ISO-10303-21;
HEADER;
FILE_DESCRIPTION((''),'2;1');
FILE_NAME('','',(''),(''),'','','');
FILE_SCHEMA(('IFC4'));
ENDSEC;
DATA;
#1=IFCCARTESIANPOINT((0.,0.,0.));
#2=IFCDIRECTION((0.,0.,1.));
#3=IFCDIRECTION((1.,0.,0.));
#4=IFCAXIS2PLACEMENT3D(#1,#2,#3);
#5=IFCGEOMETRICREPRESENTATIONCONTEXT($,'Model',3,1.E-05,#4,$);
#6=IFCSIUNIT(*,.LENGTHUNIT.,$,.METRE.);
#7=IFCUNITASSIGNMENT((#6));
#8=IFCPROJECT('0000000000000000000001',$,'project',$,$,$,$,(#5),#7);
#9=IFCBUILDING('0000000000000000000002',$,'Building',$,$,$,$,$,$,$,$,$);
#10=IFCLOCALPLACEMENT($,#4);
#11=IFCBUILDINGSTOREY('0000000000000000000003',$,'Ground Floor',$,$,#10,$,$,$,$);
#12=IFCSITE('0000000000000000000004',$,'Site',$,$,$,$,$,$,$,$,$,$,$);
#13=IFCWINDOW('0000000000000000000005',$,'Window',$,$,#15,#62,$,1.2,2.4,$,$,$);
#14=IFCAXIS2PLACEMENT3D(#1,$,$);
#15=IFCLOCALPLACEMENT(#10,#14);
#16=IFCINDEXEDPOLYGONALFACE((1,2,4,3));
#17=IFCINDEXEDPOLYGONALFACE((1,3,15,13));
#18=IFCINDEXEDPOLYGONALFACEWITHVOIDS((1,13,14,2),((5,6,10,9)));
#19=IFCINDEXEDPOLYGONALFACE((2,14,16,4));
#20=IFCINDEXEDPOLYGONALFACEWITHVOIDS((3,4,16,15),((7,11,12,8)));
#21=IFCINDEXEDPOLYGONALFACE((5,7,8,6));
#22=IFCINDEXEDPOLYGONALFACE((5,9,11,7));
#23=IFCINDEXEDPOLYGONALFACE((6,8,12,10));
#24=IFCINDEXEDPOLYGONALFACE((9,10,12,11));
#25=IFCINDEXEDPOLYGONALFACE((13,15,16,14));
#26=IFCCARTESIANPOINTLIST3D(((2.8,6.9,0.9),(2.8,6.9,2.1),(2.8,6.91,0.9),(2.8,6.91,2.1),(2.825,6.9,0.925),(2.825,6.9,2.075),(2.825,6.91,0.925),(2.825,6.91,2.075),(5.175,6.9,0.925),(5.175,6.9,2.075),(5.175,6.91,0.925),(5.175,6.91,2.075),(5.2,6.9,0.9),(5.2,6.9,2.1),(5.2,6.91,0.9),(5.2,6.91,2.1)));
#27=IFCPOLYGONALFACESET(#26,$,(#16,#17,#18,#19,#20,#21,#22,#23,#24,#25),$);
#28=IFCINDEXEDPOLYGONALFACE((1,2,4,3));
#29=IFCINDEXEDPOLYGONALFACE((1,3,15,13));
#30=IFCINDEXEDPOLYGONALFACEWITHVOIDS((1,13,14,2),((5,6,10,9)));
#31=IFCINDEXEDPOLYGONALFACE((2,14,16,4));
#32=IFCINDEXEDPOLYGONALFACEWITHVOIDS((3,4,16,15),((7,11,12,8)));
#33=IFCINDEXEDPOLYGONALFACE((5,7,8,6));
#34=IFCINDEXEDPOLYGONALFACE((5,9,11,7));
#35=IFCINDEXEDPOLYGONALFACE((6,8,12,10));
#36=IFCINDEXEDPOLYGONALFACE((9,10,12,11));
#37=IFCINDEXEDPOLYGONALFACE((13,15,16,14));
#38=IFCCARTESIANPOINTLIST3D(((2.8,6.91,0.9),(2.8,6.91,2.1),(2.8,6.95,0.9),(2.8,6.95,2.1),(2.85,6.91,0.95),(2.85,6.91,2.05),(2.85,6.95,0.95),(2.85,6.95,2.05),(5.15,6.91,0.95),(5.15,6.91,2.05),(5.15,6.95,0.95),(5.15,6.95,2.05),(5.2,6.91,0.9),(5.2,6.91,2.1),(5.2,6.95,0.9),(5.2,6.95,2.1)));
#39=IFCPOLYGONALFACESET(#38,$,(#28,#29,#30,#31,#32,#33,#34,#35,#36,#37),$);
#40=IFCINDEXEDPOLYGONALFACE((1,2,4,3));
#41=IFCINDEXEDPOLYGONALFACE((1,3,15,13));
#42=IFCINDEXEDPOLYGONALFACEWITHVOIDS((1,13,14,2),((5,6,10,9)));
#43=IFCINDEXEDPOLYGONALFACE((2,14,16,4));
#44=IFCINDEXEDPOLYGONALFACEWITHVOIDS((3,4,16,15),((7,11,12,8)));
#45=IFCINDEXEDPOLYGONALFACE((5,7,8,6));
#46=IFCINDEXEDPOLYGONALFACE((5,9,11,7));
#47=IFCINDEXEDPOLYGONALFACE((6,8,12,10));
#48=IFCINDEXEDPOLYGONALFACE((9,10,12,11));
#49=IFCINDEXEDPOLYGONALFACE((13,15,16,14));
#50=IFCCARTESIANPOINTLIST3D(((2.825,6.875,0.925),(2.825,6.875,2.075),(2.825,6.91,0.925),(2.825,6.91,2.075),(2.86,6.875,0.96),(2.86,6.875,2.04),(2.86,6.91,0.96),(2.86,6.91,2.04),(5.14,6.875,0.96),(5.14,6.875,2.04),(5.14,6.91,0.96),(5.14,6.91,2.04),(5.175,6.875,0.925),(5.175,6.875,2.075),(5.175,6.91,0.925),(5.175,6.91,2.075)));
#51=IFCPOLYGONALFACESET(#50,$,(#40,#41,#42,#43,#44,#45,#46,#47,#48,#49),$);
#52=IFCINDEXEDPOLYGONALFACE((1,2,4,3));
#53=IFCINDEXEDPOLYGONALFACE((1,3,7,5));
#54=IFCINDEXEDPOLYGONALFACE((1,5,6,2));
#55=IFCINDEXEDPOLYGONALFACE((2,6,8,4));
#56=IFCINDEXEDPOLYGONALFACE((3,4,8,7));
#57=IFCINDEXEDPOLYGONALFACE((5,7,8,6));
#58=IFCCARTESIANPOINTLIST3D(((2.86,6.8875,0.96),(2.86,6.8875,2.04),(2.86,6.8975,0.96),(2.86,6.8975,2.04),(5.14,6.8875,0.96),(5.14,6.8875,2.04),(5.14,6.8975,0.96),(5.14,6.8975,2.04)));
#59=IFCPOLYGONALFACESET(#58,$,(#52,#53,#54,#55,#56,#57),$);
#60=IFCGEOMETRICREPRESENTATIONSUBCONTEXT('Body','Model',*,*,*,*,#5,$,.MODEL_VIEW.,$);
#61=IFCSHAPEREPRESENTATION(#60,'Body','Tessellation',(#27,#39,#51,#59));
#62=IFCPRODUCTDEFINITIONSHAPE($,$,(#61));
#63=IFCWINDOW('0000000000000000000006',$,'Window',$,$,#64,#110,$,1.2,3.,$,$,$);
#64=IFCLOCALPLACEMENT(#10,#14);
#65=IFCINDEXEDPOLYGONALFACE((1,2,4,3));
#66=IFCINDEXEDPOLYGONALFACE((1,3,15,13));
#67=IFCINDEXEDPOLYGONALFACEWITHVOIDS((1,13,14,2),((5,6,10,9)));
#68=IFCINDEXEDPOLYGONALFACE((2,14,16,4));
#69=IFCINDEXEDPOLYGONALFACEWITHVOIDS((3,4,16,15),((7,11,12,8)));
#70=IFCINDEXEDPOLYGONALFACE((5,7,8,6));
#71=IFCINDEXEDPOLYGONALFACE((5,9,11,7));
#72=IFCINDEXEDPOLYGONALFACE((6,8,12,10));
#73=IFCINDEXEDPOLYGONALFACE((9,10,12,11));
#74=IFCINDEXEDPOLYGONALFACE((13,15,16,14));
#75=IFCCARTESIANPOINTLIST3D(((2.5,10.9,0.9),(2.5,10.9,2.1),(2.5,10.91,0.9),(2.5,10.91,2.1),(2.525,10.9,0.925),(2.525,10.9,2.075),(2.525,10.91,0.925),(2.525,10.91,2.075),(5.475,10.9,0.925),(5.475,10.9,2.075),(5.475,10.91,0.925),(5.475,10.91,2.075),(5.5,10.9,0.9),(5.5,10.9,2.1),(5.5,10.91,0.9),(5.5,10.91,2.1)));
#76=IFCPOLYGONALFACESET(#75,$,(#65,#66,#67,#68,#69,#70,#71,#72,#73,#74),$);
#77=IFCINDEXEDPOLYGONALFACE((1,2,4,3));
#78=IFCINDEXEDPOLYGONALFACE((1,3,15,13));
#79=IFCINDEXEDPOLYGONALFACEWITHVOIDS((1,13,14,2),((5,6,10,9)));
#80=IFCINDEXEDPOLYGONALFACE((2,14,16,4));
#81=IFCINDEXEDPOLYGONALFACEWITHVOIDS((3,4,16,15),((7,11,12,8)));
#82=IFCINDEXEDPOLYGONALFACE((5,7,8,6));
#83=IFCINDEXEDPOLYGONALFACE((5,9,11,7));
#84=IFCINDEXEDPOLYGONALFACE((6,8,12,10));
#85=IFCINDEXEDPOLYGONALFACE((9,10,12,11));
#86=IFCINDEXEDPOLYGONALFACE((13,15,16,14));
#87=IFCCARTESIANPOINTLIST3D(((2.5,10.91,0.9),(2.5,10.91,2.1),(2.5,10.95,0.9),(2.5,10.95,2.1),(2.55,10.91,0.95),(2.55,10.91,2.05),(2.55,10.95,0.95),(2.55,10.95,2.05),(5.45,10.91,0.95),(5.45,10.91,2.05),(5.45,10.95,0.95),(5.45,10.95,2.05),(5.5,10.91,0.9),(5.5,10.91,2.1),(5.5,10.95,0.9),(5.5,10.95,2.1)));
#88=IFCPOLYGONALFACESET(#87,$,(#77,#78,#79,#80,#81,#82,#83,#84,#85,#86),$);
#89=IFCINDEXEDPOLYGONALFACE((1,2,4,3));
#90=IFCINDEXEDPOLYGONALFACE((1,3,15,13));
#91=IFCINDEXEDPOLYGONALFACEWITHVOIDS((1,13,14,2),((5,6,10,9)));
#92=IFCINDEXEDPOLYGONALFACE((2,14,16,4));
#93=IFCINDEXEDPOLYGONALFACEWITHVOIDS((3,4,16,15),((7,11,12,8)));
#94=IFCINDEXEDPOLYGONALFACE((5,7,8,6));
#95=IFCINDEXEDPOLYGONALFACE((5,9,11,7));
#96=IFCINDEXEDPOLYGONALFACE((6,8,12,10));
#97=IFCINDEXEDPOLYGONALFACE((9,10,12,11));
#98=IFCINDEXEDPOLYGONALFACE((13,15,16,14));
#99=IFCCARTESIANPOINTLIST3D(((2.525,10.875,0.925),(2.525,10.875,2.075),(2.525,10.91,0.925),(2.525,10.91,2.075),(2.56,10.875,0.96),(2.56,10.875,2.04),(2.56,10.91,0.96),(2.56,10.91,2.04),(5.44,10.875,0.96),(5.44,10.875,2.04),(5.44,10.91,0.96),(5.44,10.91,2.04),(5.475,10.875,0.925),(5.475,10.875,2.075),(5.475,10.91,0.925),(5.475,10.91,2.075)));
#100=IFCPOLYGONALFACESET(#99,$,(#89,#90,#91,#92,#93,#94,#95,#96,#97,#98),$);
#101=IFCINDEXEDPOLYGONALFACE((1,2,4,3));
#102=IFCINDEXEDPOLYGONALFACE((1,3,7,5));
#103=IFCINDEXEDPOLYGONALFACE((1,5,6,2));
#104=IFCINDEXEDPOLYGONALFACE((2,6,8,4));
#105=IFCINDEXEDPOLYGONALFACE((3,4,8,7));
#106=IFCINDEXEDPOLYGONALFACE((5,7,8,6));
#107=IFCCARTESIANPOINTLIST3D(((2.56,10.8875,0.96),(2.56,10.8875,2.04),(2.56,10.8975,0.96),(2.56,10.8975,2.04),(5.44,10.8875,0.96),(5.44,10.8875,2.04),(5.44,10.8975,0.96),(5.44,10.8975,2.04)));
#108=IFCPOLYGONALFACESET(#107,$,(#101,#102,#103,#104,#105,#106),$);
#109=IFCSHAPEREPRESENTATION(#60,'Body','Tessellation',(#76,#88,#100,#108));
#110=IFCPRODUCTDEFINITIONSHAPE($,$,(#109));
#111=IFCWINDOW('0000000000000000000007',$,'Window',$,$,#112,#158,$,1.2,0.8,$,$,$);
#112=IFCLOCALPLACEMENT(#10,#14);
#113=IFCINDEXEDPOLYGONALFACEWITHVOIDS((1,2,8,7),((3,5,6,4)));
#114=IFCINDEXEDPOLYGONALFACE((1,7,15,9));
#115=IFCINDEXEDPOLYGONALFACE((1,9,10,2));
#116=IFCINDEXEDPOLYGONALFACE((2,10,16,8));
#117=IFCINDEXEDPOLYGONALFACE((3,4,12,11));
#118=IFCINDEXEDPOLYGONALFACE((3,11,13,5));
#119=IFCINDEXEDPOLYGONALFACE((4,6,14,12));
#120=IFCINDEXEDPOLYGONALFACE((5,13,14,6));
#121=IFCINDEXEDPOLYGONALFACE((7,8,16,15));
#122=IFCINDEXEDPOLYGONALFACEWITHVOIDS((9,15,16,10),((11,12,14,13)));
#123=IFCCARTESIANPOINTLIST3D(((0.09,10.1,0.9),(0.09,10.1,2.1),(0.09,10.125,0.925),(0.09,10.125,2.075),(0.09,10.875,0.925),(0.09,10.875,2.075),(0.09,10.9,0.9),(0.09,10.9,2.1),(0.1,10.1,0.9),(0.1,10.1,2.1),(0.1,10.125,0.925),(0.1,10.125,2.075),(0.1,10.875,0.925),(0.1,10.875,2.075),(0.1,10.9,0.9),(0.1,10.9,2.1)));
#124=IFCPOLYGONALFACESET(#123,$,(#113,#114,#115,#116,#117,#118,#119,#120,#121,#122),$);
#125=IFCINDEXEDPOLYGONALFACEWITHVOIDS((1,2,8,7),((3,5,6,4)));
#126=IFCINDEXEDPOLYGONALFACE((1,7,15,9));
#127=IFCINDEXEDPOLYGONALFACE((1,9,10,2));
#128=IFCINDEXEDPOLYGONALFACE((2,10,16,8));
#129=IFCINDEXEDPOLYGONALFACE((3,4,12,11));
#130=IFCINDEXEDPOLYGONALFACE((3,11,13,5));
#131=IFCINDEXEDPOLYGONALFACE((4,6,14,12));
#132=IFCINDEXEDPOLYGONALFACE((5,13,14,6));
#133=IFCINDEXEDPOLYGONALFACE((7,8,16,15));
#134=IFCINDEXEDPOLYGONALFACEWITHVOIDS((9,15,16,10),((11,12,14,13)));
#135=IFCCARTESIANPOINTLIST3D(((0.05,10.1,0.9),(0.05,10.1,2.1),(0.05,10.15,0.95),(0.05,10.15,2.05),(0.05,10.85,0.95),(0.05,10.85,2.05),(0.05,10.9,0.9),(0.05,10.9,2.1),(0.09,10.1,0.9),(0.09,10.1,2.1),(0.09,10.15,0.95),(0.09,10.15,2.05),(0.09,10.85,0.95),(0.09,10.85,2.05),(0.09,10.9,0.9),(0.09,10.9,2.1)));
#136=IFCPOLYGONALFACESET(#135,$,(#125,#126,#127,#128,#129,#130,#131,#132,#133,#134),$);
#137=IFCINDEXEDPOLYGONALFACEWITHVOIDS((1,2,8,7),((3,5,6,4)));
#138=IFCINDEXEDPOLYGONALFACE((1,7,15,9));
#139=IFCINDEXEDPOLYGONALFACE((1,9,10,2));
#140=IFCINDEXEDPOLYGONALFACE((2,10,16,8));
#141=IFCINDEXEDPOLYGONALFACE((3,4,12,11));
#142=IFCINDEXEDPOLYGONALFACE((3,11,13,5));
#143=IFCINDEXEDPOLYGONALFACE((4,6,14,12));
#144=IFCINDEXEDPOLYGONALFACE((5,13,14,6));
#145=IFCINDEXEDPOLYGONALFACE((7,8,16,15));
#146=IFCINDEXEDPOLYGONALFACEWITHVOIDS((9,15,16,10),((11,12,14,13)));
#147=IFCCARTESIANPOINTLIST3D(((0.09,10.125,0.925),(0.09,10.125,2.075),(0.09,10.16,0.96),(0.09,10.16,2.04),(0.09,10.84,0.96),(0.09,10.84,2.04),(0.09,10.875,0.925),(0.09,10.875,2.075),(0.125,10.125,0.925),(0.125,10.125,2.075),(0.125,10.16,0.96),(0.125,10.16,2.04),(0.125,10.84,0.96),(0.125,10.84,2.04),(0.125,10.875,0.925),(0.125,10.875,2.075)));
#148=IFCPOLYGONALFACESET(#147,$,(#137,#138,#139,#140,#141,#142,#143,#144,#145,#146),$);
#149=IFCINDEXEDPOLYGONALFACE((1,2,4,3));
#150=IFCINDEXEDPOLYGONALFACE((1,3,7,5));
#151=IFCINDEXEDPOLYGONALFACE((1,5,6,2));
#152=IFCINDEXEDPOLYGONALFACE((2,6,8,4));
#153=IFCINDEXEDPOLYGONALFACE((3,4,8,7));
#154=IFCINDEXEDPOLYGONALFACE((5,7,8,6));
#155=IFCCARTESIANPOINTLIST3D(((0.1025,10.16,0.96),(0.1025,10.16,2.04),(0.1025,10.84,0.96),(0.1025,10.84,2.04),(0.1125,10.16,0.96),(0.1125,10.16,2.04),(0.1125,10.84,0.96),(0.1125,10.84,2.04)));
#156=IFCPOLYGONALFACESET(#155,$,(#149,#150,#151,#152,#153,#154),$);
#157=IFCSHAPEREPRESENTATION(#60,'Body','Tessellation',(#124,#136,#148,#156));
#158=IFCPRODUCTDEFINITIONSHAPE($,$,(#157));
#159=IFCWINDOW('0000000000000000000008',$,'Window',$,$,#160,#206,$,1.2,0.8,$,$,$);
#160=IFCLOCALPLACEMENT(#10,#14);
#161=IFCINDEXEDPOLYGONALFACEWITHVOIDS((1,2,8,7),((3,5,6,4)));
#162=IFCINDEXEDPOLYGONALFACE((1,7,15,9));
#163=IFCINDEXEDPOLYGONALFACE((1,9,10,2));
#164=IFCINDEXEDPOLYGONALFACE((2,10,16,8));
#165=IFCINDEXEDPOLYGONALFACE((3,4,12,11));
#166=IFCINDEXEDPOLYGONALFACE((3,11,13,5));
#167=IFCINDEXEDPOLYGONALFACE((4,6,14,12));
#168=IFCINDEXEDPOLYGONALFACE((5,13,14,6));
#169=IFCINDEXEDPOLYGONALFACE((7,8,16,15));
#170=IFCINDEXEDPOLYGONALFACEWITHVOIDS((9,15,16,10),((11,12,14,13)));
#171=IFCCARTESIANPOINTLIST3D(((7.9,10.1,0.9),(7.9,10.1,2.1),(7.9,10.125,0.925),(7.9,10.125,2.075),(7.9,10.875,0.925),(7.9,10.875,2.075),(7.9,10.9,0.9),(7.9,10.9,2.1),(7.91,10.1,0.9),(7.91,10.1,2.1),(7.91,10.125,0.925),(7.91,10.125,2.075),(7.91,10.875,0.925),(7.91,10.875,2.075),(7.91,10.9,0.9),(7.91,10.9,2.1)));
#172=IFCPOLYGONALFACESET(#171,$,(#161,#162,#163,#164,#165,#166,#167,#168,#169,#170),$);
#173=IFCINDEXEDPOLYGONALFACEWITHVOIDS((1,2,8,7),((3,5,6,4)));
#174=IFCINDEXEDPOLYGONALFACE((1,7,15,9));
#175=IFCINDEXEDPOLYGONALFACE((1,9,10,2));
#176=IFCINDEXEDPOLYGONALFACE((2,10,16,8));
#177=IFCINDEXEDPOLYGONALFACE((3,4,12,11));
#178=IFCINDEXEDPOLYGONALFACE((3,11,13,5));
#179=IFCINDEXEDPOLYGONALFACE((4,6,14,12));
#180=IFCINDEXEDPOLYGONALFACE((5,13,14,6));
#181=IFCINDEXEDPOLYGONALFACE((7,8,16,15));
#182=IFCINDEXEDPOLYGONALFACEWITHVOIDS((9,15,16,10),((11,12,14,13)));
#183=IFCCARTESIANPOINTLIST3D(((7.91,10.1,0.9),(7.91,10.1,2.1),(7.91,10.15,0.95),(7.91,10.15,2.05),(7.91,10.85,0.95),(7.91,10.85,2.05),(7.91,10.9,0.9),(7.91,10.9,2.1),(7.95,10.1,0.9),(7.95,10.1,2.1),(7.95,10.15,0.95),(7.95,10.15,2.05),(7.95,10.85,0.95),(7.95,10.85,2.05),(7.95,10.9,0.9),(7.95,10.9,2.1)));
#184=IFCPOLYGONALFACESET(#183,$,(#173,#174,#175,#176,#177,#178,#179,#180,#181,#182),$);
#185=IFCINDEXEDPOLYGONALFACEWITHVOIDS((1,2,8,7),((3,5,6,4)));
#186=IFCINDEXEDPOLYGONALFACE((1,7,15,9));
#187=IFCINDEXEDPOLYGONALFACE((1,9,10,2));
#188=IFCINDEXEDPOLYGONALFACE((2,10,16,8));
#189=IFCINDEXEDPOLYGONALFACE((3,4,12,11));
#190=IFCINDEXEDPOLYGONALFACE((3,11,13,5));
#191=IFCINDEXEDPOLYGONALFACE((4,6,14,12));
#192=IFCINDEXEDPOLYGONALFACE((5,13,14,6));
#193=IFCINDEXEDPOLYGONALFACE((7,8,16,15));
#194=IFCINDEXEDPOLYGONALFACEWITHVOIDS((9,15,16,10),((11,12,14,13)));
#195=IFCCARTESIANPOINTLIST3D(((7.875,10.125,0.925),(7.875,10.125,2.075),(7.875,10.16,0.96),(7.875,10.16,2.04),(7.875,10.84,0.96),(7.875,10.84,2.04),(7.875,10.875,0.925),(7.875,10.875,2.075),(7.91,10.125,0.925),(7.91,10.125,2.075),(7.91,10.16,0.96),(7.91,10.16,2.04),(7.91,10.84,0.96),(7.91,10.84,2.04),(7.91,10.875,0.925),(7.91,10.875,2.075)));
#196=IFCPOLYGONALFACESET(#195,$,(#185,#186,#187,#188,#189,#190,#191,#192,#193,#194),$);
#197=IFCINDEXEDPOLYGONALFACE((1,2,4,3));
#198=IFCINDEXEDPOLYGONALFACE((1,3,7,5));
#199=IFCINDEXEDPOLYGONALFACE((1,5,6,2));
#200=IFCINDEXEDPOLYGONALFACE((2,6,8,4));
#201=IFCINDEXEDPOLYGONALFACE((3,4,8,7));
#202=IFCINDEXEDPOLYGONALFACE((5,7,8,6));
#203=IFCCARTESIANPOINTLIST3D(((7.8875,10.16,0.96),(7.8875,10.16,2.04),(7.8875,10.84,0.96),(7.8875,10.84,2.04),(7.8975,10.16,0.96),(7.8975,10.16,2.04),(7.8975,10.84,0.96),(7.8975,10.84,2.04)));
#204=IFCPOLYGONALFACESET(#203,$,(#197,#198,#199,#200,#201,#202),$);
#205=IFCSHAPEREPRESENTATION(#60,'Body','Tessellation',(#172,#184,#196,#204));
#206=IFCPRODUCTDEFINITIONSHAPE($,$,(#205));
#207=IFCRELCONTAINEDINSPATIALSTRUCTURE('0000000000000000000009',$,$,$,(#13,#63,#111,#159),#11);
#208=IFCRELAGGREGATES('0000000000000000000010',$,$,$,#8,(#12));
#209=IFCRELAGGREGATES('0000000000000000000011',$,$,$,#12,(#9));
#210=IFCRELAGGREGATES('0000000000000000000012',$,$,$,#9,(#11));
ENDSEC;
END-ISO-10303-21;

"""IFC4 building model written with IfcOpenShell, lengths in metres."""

from ifc_helpers import new_model, si_unit, frame, origin_with_axes, place, context, subcontext, project, spatial, line, indexed_curve, outline, extrude, element, save


model = new_model("IFC4")

# Units and contexts
model_context = context("Model", 3, precision=1e-05, world=origin_with_axes())
body_context = subcontext(model_context, "Body", "Model", "MODEL_VIEW")
ifc_project = project(units=[si_unit("LENGTHUNIT", "METRE")], contexts=[model_context])

# Site, building, storey
site = spatial("IfcSite", under=ifc_project, Name="Site")
building = spatial("IfcBuilding", under=site, Name="Building")
storey_placement = place(None, origin_with_axes())
storey = spatial("IfcBuildingStorey", under=building, at=storey_placement, Name="Ground Floor")

# Windows
window_1_placement = place(storey_placement, frame((5.2, 7.0, 0.9), z_axis=(0.0, 0.0, 1.0), x_axis=(-1.0, 0.0, 0.0)))
element("IfcWindow", 1, at=window_1_placement, inside=storey, Name="Window", OverallHeight=1.2, OverallWidth=2.4, context=body_context, shape_type="SweptSolid", body=[
    extrude(outline(indexed_curve([(0.0, 0.0), (2.4, 0.0), (2.4, 1.2), (0.0, 1.2)], segments=[line(1, 2, 3, 4, 1)]), holes=[indexed_curve([(0.025, 0.025), (2.375, 0.025), (2.375, 1.175), (0.025, 1.175)], segments=[line(1, 2, 3, 4, 1)])]), frame((0.0, 0.09, 0.0), z_axis=(0.0, -1.0, 0.0), x_axis=(1.0, 0.0, 0.0)), (0.0, 0.0, -1.0), 0.01),
    extrude(outline(indexed_curve([(0.0, 0.0), (2.4, 0.0), (2.4, 1.2), (0.0, 1.2)], segments=[line(1, 2, 3, 4, 1)]), holes=[indexed_curve([(0.05, 0.05), (2.35, 0.05), (2.35, 1.15), (0.05, 1.15)], segments=[line(1, 2, 3, 4, 1)])]), frame((0.0, 0.05, 0.0), z_axis=(0.0, -1.0, 0.0), x_axis=(1.0, 0.0, 0.0)), (0.0, 0.0, -1.0), 0.04),
    extrude(outline(indexed_curve([(0.0, 0.0), (2.35, 0.0), (2.35, 1.15), (0.0, 1.15)], segments=[line(1, 2, 3, 4, 1)]), holes=[indexed_curve([(0.035, 0.035), (2.315, 0.035), (2.315, 1.115), (0.035, 1.115)], segments=[line(1, 2, 3, 4, 1)])]), frame((0.025, 0.09, 0.025), z_axis=(0.0, -1.0, 0.0), x_axis=(1.0, 0.0, 0.0)), (0.0, 0.0, -1.0), 0.035),
    extrude(outline(indexed_curve([(0.035, 0.035), (2.315, 0.035), (2.315, 1.115), (0.035, 1.115)], segments=[line(1, 2, 3, 4, 1)])), frame((0.025, 0.1025, 0.025), z_axis=(0.0, -1.0, 0.0), x_axis=(1.0, 0.0, 0.0)), (0.0, 0.0, -1.0), 0.01),
])
window_2_placement = place(storey_placement, frame((5.5, 11.0, 0.9), z_axis=(0.0, 0.0, 1.0), x_axis=(-1.0, 0.0, 0.0)))
element("IfcWindow", 2, at=window_2_placement, inside=storey, Name="Window", OverallHeight=1.2, OverallWidth=3.0, context=body_context, shape_type="SweptSolid", body=[
    extrude(outline(indexed_curve([(0.0, 0.0), (3.0, 0.0), (3.0, 1.2), (0.0, 1.2)], segments=[line(1, 2, 3, 4, 1)]), holes=[indexed_curve([(0.025, 0.025), (2.975, 0.025), (2.975, 1.175), (0.025, 1.175)], segments=[line(1, 2, 3, 4, 1)])]), frame((0.0, 0.09, 0.0), z_axis=(0.0, -1.0, 0.0), x_axis=(1.0, 0.0, 0.0)), (0.0, 0.0, -1.0), 0.01),
    extrude(outline(indexed_curve([(0.0, 0.0), (3.0, 0.0), (3.0, 1.2), (0.0, 1.2)], segments=[line(1, 2, 3, 4, 1)]), holes=[indexed_curve([(0.05, 0.05), (2.95, 0.05), (2.95, 1.15), (0.05, 1.15)], segments=[line(1, 2, 3, 4, 1)])]), frame((0.0, 0.05, 0.0), z_axis=(0.0, -1.0, 0.0), x_axis=(1.0, 0.0, 0.0)), (0.0, 0.0, -1.0), 0.04),
    extrude(outline(indexed_curve([(0.0, 0.0), (2.95, 0.0), (2.95, 1.15), (0.0, 1.15)], segments=[line(1, 2, 3, 4, 1)]), holes=[indexed_curve([(0.035, 0.035), (2.915, 0.035), (2.915, 1.115), (0.035, 1.115)], segments=[line(1, 2, 3, 4, 1)])]), frame((0.025, 0.09, 0.025), z_axis=(0.0, -1.0, 0.0), x_axis=(1.0, 0.0, 0.0)), (0.0, 0.0, -1.0), 0.035),
    extrude(outline(indexed_curve([(0.035, 0.035), (2.915, 0.035), (2.915, 1.115), (0.035, 1.115)], segments=[line(1, 2, 3, 4, 1)])), frame((0.025, 0.1025, 0.025), z_axis=(0.0, -1.0, 0.0), x_axis=(1.0, 0.0, 0.0)), (0.0, 0.0, -1.0), 0.01),
])
for number, where, z_axis, x_axis, name in (
    (3, (0.0, 10.9, 0.9), (0.0, 0.0, 1.0), (0.0, -1.0, 0.0), "Window"),
    (4, (8.0, 10.1, 0.9), (0.0, 0.0, 1.0), (0.0, 1.0, 0.0), "Window"),
):
    element("IfcWindow", number, at=place(storey_placement, frame(where, z_axis=z_axis, x_axis=x_axis)), inside=storey, Name=name, OverallHeight=1.2, OverallWidth=0.8, context=body_context, shape_type="SweptSolid", body=[
        extrude(outline(indexed_curve([(0.0, 0.0), (0.8, 0.0), (0.8, 1.2), (0.0, 1.2)], segments=[line(1, 2, 3, 4, 1)]), holes=[indexed_curve([(0.025, 0.025), (0.775, 0.025), (0.775, 1.175), (0.025, 1.175)], segments=[line(1, 2, 3, 4, 1)])]), frame((0.0, 0.09, 0.0), z_axis=(0.0, -1.0, 0.0), x_axis=(1.0, 0.0, 0.0)), (0.0, 0.0, -1.0), 0.01),
        extrude(outline(indexed_curve([(0.0, 0.0), (0.8, 0.0), (0.8, 1.2), (0.0, 1.2)], segments=[line(1, 2, 3, 4, 1)]), holes=[indexed_curve([(0.05, 0.05), (0.75, 0.05), (0.75, 1.15), (0.05, 1.15)], segments=[line(1, 2, 3, 4, 1)])]), frame((0.0, 0.05, 0.0), z_axis=(0.0, -1.0, 0.0), x_axis=(1.0, 0.0, 0.0)), (0.0, 0.0, -1.0), 0.04),
        extrude(outline(indexed_curve([(0.0, 0.0), (0.75, 0.0), (0.75, 1.15), (0.0, 1.15)], segments=[line(1, 2, 3, 4, 1)]), holes=[indexed_curve([(0.035, 0.035), (0.715, 0.035), (0.715, 1.115), (0.035, 1.115)], segments=[line(1, 2, 3, 4, 1)])]), frame((0.025, 0.09, 0.025), z_axis=(0.0, -1.0, 0.0), x_axis=(1.0, 0.0, 0.0)), (0.0, 0.0, -1.0), 0.035),
        extrude(outline(indexed_curve([(0.035, 0.035), (0.715, 0.035), (0.715, 1.115), (0.035, 1.115)], segments=[line(1, 2, 3, 4, 1)])), frame((0.025, 0.1025, 0.025), z_axis=(0.0, -1.0, 0.0), x_axis=(1.0, 0.0, 0.0)), (0.0, 0.0, -1.0), 0.01),
    ])

save(model, "model.ifc")
